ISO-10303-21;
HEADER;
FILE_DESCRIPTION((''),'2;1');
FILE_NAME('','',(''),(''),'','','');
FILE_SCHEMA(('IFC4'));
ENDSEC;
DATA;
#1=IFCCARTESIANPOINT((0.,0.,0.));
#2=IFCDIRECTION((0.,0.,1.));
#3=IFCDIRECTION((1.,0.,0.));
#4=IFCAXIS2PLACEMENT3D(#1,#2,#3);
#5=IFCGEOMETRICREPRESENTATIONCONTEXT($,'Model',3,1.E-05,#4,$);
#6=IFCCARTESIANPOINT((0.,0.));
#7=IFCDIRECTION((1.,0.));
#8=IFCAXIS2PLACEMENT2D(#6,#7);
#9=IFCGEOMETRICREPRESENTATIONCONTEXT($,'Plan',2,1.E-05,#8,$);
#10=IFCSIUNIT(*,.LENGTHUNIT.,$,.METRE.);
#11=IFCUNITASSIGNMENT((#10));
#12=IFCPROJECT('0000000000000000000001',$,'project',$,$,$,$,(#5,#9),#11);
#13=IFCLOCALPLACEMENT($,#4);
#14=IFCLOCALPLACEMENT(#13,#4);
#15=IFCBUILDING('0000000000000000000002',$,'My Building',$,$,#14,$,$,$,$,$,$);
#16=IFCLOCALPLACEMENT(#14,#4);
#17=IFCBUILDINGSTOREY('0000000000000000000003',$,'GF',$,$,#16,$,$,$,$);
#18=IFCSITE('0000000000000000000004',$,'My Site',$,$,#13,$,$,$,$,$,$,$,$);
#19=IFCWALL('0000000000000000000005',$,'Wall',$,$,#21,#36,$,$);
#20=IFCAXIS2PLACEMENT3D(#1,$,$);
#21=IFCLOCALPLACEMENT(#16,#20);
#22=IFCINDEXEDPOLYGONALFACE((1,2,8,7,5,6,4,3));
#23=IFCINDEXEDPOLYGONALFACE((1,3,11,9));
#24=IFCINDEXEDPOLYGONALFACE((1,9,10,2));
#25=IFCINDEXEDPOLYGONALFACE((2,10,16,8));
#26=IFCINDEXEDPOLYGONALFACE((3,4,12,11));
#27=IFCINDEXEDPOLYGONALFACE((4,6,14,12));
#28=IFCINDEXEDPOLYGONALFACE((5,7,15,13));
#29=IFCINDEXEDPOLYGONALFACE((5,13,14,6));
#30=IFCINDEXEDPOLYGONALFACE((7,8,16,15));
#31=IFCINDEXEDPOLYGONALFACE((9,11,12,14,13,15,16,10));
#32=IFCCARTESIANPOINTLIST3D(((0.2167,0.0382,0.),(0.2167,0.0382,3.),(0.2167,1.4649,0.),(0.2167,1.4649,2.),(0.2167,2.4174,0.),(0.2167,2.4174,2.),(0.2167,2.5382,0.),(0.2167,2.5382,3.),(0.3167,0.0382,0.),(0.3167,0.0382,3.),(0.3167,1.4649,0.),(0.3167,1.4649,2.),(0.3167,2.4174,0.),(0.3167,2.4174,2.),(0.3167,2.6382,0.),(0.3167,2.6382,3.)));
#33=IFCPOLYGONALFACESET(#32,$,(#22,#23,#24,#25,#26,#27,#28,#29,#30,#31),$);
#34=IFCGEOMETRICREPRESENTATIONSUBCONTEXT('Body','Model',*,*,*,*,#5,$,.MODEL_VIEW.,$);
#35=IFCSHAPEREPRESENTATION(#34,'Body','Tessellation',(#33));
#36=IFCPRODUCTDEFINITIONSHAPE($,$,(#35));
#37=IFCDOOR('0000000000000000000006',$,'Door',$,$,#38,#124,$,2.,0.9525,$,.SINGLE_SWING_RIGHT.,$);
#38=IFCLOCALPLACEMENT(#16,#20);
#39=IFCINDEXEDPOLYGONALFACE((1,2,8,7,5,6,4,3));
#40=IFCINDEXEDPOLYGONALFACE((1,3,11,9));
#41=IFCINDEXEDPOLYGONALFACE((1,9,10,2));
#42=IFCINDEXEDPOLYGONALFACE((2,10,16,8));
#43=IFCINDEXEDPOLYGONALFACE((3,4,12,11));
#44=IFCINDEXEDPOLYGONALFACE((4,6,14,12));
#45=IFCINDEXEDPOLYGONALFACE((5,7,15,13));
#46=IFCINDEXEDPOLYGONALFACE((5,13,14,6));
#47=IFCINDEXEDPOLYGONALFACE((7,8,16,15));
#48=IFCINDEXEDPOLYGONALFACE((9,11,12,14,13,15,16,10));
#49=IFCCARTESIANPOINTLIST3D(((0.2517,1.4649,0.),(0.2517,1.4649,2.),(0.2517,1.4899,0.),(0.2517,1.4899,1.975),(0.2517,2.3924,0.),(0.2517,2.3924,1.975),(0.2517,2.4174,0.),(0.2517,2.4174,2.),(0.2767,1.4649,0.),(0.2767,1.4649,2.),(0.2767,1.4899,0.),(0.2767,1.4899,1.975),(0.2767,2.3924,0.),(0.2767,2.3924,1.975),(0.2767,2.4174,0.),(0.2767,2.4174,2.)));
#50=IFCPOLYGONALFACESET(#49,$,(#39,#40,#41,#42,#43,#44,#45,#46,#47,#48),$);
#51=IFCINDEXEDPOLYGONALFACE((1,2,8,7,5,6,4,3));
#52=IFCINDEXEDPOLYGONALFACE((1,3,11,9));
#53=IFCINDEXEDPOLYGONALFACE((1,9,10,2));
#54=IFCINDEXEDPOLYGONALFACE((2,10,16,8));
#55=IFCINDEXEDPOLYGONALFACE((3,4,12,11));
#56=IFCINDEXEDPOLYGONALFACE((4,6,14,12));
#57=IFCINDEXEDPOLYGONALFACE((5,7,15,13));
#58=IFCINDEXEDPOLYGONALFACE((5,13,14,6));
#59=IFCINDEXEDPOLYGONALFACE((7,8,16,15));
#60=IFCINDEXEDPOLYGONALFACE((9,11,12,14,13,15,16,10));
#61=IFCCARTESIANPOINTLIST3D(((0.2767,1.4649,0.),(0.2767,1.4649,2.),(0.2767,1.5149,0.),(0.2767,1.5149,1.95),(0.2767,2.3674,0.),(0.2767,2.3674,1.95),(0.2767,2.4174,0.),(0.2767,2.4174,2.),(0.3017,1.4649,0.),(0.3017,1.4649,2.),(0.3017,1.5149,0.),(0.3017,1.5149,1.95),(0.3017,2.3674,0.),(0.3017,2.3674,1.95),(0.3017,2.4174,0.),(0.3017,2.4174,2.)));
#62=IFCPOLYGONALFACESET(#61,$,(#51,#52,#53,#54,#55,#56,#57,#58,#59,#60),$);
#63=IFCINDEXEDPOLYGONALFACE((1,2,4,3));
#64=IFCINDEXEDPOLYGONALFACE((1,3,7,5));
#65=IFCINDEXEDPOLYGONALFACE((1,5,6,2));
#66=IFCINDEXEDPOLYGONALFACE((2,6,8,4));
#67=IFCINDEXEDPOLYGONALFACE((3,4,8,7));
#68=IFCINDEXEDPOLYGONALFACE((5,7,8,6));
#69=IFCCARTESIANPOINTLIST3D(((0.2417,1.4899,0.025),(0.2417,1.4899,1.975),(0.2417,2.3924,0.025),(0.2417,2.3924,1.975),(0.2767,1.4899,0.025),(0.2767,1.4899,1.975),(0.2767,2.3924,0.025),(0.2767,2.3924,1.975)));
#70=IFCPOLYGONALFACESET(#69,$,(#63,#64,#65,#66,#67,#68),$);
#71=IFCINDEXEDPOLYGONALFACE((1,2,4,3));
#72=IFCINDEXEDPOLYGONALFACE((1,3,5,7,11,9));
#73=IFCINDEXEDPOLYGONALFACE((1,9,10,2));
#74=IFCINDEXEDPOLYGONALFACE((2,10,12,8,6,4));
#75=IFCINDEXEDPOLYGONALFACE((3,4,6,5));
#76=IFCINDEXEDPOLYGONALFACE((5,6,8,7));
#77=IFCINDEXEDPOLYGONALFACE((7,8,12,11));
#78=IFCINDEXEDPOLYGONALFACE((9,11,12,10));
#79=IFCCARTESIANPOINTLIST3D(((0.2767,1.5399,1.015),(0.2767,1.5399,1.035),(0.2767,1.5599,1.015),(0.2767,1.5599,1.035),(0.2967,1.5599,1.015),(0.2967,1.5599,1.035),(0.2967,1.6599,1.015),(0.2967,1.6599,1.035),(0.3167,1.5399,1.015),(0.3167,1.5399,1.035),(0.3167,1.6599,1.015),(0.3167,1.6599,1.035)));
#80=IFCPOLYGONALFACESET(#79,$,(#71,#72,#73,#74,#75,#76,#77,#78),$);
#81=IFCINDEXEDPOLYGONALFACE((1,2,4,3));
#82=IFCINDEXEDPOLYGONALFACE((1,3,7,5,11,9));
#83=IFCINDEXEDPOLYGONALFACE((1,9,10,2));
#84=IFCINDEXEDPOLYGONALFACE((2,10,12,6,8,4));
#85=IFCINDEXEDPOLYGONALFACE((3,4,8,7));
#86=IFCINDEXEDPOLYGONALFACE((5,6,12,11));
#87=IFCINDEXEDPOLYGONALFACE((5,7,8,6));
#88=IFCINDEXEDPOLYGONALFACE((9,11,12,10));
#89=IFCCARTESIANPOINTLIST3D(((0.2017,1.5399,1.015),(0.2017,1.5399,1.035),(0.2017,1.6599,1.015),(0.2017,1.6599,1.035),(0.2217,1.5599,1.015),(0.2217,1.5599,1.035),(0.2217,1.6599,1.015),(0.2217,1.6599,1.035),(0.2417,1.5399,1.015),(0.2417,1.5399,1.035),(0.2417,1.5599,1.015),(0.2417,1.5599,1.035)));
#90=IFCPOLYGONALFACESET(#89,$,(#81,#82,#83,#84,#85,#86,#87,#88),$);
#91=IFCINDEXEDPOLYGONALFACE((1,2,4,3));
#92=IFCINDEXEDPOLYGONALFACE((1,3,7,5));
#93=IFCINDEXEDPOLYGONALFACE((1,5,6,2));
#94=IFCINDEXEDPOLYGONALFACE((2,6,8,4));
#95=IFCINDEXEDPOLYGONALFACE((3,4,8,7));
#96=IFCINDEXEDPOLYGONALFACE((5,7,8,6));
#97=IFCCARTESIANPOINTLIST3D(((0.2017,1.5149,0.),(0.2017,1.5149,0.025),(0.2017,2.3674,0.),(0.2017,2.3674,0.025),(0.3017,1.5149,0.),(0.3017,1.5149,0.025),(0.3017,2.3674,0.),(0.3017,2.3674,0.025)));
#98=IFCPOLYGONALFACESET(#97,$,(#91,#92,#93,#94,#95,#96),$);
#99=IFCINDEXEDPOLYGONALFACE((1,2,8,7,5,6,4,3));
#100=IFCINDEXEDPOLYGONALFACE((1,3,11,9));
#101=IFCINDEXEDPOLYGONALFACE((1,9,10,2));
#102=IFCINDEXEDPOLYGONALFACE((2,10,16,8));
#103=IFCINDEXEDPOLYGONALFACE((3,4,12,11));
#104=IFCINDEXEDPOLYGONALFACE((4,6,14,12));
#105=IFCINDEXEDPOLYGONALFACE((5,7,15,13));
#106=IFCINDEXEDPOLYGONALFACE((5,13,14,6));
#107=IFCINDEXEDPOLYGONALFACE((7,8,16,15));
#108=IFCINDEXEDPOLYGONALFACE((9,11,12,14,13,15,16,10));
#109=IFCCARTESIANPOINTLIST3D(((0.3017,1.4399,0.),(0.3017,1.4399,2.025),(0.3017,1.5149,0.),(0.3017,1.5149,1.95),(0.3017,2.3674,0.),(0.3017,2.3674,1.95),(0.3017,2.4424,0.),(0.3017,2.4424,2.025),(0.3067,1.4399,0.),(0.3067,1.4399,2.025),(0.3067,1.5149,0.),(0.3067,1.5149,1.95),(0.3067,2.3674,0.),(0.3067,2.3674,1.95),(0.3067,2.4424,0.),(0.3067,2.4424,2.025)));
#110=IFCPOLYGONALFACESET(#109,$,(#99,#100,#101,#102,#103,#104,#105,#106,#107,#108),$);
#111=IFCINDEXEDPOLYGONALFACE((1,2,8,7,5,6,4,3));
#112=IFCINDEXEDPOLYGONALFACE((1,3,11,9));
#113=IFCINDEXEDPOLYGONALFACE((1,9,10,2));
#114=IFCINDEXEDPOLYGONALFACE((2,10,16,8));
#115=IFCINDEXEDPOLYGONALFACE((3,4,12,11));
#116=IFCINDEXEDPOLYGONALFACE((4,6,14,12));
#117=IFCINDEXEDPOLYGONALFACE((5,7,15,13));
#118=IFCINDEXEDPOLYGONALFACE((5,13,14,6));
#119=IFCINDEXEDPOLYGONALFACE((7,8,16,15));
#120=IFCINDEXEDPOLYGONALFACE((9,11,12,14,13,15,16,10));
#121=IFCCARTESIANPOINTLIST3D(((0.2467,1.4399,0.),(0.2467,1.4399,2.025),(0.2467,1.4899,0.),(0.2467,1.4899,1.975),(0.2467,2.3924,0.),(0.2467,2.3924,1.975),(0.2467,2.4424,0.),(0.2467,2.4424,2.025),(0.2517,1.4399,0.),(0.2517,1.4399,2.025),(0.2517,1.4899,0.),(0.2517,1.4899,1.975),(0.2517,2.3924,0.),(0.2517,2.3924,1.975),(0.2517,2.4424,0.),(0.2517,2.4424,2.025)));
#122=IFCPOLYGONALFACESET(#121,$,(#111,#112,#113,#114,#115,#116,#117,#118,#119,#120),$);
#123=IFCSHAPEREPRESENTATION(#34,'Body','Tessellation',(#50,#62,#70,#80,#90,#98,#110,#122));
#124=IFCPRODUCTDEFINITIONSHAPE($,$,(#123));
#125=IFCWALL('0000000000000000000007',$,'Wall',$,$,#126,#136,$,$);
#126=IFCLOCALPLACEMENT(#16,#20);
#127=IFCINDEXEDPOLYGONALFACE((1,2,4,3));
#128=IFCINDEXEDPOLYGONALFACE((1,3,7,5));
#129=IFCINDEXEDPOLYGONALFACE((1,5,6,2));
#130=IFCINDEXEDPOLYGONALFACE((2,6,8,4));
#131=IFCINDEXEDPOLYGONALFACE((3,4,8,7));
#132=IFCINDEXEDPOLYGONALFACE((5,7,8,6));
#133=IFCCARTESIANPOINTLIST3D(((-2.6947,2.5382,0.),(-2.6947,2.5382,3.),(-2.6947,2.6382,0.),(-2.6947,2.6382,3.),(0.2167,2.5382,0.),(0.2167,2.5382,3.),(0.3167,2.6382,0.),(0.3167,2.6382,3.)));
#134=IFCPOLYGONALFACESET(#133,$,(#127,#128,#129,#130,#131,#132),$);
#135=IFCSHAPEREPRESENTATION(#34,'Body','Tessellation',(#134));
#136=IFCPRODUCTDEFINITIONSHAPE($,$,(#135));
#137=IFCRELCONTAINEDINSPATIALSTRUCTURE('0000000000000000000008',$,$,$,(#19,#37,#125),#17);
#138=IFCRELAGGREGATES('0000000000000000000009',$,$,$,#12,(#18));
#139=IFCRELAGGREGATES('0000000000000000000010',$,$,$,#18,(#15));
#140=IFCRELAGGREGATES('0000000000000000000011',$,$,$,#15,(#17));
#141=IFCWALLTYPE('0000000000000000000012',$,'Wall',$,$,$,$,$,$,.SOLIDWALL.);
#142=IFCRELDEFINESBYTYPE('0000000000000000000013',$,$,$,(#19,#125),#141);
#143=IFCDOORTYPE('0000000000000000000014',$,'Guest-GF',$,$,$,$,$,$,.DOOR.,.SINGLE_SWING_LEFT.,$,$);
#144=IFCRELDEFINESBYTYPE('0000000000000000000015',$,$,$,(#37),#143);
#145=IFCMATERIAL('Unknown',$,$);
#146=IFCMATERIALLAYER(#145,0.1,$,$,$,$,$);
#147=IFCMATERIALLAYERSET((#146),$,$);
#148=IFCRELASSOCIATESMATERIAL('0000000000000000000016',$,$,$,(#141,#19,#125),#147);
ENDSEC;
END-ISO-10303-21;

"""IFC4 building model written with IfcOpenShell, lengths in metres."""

from ifc_helpers import new_model, entity, si_unit, frame, origin_with_axes, origin_2d_with_axis, place, context, subcontext, project, spatial, line, indexed_curve, outline, extrude, shape, source, transform, mapped, material, layer, layer_set, layer_usage, type_object, type_shapes, element, fill, save


model = new_model("IFC4")

# Units and contexts
model_context = context("Model", 3, precision=1e-05, world=origin_with_axes())
plan_context = context("Plan", 2, precision=1e-05, world=origin_2d_with_axis())
body_context_1 = subcontext(model_context, "Body", "Model", "MODEL_VIEW")
body_context_2 = subcontext(plan_context, "Body", "Plan", "PLAN_VIEW")
ifc_project = project(units=[si_unit("LENGTHUNIT", "METRE")], contexts=[model_context, plan_context])

# Site, building, storey
site_placement = place(None, origin_with_axes())
site = spatial("IfcSite", under=ifc_project, at=site_placement, Name="My Site")
building_placement = place(site_placement, origin_with_axes())
building = spatial("IfcBuilding", under=site, at=building_placement, Name="My Building")
storey_placement = place(building_placement, origin_with_axes())
storey = spatial("IfcBuildingStorey", under=building, at=storey_placement, Name="GF")

# Shared definitions
ifc_material = material(Name="Unknown")

# Shared definitions
ifc_layer_1 = layer(ifc_material, 0.1)
ifc_layer_set_1 = layer_set([ifc_layer_1])
wall_type = type_object("IfcWallType", Name="Wall", PredefinedType="SOLIDWALL", material=ifc_layer_set_1)

# Wall, opening, door
ifc_layer_usage_1 = layer_usage(ifc_layer_set_1, "AXIS2", "POSITIVE", 0.0)
wall_1_placement = place(storey_placement, frame((0.3167, 0.0382, 0.0), z_axis=(0.0, 0.0, 1.0), x_axis=(0.0, 1.0, 0.0)))
wall_1 = element("IfcWall", 1, at=wall_1_placement, inside=storey, type_object=wall_type, material=ifc_layer_usage_1, Name="Wall", context=body_context_1, shape_type="SweptSolid", body=[
    extrude(outline(indexed_curve([(0.0, 0.0), (0.0, 0.1), (2.5, 0.1), (2.6, 0.0)], segments=[line(1, 2, 3, 4, 1)])), origin_with_axes(), (0.0, 0.0, 1.0), 3.0),
])
shared_shape_1 = source(origin_with_axes(), body_context_1, "Body", "SweptSolid", [
    extrude(outline(indexed_curve([(0.0, 0.0), (0.9525, 0.0), (0.9525, 2.0), (0.0, 2.0)], segments=[line(1, 2, 3, 4, 1)])), frame((0.0, -0.6, 0.0), z_axis=(0.0, -1.0, 0.0), x_axis=(1.0, 0.0, 0.0)), (0.0, 0.0, -1.0), 1.2),
])
opening_1_placement = place(wall_1_placement, frame((1.4267, 0.015, 0.0), z_axis=(0.0, 0.0, 1.0), x_axis=(1.0, 0.0, 0.0)))
opening_1 = element("IfcOpeningElement", 2, at=opening_1_placement, cuts=wall_1, PredefinedType="OPENING", context=body_context_1, shape_type="MappedRepresentation", body=[
    mapped(shared_shape_1, transform((0.0, 0.0, 0.0), x_axis=(1.0, 0.0, 0.0), y_axis=(0.0, 1.0, 0.0), z_axis=(0.0, 0.0, 1.0), scale=1.0)),
])
door_type_1 = type_object("IfcDoorType", Name="Guest-GF", OperationType="SINGLE_SWING_LEFT", PredefinedType="DOOR")
shared_shape_2 = source(origin_with_axes(), body_context_1, "Body", "SweptSolid", [
    extrude(outline(indexed_curve([(0.0, 0.0), (0.0, 2.0), (0.9525, 2.0), (0.9525, 0.0), (0.9275, 0.0), (0.9275, 1.975), (0.025, 1.975), (0.025, 0.0)], segments=[line(1, 2, 3, 4, 5, 6, 7, 8, 1)])), frame((0.0, 0.025, 0.0), z_axis=(0.0, -1.0, 0.0), x_axis=(1.0, 0.0, 0.0)), (0.0, 0.0, -1.0), 0.025),
    extrude(outline(indexed_curve([(0.0, 0.0), (0.0, 2.0), (0.9525, 2.0), (0.9525, 0.0), (0.9025, 0.0), (0.9025, 1.95), (0.05, 1.95), (0.05, 0.0)], segments=[line(1, 2, 3, 4, 5, 6, 7, 8, 1)])), frame((0.0, 0.0, 0.0), z_axis=(0.0, -1.0, 0.0), x_axis=(1.0, 0.0, 0.0)), (0.0, 0.0, -1.0), 0.025),
    extrude(outline(indexed_curve([(0.0, 0.0), (0.9025, 0.0), (0.9025, 0.035), (0.0, 0.035)], segments=[line(1, 2, 3, 4, 1)])), frame((0.025, 0.025, 0.025), z_axis=(0.0, 0.0, 1.0), x_axis=(1.0, 0.0, 0.0)), (0.0, 0.0, 1.0), 1.95),
    extrude(outline(indexed_curve([(0.0, 0.0), (0.0, -0.04), (0.12, -0.04), (0.12, -0.02), (0.02, -0.02), (0.02, 0.0)], segments=[line(1, 2, 3, 4, 5, 6, 1)])), frame((0.075, 0.025, 1.015), z_axis=(0.0, 0.0, 1.0), x_axis=(1.0, 0.0, 0.0)), (0.0, 0.0, 1.0), 0.02),
    extrude(outline(indexed_curve([(0.0, 0.0), (0.0, 0.04), (0.12, 0.04), (0.12, 0.02), (0.02, 0.02), (0.02, 0.0)], segments=[line(1, 2, 3, 4, 5, 6, 1)])), frame((0.075, 0.06, 1.015), z_axis=(0.0, 0.0, 1.0), x_axis=(1.0, 0.0, 0.0)), (0.0, 0.0, 1.0), 0.02),
    extrude(outline(indexed_curve([(0.0, 0.0), (0.8525, 0.0), (0.8525, 0.1), (0.0, 0.1)], segments=[line(1, 2, 3, 4, 1)])), frame((0.05, 0.0, 0.0), z_axis=(0.0, 0.0, 1.0), x_axis=(1.0, 0.0, 0.0)), (0.0, 0.0, 1.0), 0.025),
    extrude(outline(indexed_curve([(0.0, 0.0), (0.0, 2.025), (1.0025, 2.025), (1.0025, 0.0), (0.9275, 0.0), (0.9275, 1.95), (0.075, 1.95), (0.075, 0.0)], segments=[line(1, 2, 3, 4, 5, 6, 7, 8, 1)])), frame((-0.025, -0.005, 0.0), z_axis=(0.0, -1.0, 0.0), x_axis=(1.0, 0.0, 0.0)), (0.0, 0.0, -1.0), 0.005),
    extrude(outline(indexed_curve([(0.0, 0.0), (0.0, 2.025), (1.0025, 2.025), (1.0025, 0.0), (0.9525, 0.0), (0.9525, 1.975), (0.05, 1.975), (0.05, 0.0)], segments=[line(1, 2, 3, 4, 5, 6, 7, 8, 1)])), frame((-0.025, 0.05, 0.0), z_axis=(0.0, -1.0, 0.0), x_axis=(1.0, 0.0, 0.0)), (0.0, 0.0, -1.0), 0.005),
])
shared_shape_3 = source(origin_with_axes(), body_context_2, "Body", "Curve2D", [
    entity("IfcIndexedPolyCurve", entity("IfcCartesianPointList2D", [[0.0, 0.0], [0.0, 0.05], [0.025, 0.05], [0.025, 0.025], [0.05, 0.025], [0.05, 0.0]]), [entity("IfcLineIndex", [1, 2, 3, 4, 5, 6, 1])]),
    entity("IfcIndexedPolyCurve", entity("IfcCartesianPointList2D", [[0.9525, 0.0], [0.9525, 0.05], [0.9275, 0.05], [0.9275, 0.025], [0.9025, 0.025], [0.9025, 0.0]]), [entity("IfcLineIndex", [1, 2, 3, 4, 5, 6, 1])]),
    entity("IfcTrimmedCurve", entity("IfcEllipse", entity("IfcAxis2Placement2D", entity("IfcCartesianPoint", [0.8925, 0.05]), entity("IfcDirection", [1.0, 0.0])), 0.8675, 0.9025), [entity("IfcCartesianPoint", [0.8925, 0.9525])], [entity("IfcCartesianPoint", [0.025, 0.05])], True, "CARTESIAN"),
    entity("IfcIndexedPolyCurve", entity("IfcCartesianPointList2D", [[0.9275, 0.05], [0.8925, 0.05], [0.8925, 0.9525], [0.9275, 0.9525]]), [entity("IfcLineIndex", [1, 2, 3, 4, 1])]),
])
type_shapes(door_type_1, [shared_shape_2, shared_shape_3])
door_1_placement = place(opening_1_placement, frame((0.0, 0.0, 0.0), z_axis=(0.0, 0.0, 1.0), x_axis=(1.0, 0.0, 0.0)))
door_1 = element("IfcDoor", 3, at=door_1_placement, inside=storey, type_object=door_type_1, Name="Door", OperationType="SINGLE_SWING_RIGHT", OverallHeight=2.0, OverallWidth=0.9525, shapes=[
    shape(body_context_1, "Body", "MappedRepresentation", [mapped(shared_shape_2, transform((0.0, 0.0, 0.0), x_axis=(1.0, 0.0, 0.0), y_axis=(0.0, 1.0, 0.0), z_axis=(0.0, 0.0, 1.0), scale=1.0))]),
    shape(body_context_2, "Body", "MappedRepresentation", [mapped(shared_shape_3, transform((0.0, 0.0, 0.0), x_axis=(1.0, 0.0, 0.0), y_axis=(0.0, 1.0, 0.0), z_axis=(0.0, 0.0, 1.0), scale=1.0))]),
])
fill(opening_1, door_1)

# Wall
ifc_layer_usage_2 = layer_usage(ifc_layer_set_1, "AXIS2", "POSITIVE", 0.0)
wall_2_placement = place(storey_placement, frame((0.3167, 2.6382, 0.0), z_axis=(0.0, 0.0, 1.0), x_axis=(-1.0, 0.0, 0.0)))
element("IfcWall", 4, at=wall_2_placement, inside=storey, type_object=wall_type, material=ifc_layer_usage_2, Name="Wall", context=body_context_1, shape_type="SweptSolid", body=[
    extrude(outline(indexed_curve([(0.0, 0.0), (0.1, 0.1), (3.0114, 0.1), (3.0114, 0.0)], segments=[line(1, 2, 3, 4, 1)])), origin_with_axes(), (0.0, 0.0, 1.0), 3.0),
])

save(model, "model.ifc")
